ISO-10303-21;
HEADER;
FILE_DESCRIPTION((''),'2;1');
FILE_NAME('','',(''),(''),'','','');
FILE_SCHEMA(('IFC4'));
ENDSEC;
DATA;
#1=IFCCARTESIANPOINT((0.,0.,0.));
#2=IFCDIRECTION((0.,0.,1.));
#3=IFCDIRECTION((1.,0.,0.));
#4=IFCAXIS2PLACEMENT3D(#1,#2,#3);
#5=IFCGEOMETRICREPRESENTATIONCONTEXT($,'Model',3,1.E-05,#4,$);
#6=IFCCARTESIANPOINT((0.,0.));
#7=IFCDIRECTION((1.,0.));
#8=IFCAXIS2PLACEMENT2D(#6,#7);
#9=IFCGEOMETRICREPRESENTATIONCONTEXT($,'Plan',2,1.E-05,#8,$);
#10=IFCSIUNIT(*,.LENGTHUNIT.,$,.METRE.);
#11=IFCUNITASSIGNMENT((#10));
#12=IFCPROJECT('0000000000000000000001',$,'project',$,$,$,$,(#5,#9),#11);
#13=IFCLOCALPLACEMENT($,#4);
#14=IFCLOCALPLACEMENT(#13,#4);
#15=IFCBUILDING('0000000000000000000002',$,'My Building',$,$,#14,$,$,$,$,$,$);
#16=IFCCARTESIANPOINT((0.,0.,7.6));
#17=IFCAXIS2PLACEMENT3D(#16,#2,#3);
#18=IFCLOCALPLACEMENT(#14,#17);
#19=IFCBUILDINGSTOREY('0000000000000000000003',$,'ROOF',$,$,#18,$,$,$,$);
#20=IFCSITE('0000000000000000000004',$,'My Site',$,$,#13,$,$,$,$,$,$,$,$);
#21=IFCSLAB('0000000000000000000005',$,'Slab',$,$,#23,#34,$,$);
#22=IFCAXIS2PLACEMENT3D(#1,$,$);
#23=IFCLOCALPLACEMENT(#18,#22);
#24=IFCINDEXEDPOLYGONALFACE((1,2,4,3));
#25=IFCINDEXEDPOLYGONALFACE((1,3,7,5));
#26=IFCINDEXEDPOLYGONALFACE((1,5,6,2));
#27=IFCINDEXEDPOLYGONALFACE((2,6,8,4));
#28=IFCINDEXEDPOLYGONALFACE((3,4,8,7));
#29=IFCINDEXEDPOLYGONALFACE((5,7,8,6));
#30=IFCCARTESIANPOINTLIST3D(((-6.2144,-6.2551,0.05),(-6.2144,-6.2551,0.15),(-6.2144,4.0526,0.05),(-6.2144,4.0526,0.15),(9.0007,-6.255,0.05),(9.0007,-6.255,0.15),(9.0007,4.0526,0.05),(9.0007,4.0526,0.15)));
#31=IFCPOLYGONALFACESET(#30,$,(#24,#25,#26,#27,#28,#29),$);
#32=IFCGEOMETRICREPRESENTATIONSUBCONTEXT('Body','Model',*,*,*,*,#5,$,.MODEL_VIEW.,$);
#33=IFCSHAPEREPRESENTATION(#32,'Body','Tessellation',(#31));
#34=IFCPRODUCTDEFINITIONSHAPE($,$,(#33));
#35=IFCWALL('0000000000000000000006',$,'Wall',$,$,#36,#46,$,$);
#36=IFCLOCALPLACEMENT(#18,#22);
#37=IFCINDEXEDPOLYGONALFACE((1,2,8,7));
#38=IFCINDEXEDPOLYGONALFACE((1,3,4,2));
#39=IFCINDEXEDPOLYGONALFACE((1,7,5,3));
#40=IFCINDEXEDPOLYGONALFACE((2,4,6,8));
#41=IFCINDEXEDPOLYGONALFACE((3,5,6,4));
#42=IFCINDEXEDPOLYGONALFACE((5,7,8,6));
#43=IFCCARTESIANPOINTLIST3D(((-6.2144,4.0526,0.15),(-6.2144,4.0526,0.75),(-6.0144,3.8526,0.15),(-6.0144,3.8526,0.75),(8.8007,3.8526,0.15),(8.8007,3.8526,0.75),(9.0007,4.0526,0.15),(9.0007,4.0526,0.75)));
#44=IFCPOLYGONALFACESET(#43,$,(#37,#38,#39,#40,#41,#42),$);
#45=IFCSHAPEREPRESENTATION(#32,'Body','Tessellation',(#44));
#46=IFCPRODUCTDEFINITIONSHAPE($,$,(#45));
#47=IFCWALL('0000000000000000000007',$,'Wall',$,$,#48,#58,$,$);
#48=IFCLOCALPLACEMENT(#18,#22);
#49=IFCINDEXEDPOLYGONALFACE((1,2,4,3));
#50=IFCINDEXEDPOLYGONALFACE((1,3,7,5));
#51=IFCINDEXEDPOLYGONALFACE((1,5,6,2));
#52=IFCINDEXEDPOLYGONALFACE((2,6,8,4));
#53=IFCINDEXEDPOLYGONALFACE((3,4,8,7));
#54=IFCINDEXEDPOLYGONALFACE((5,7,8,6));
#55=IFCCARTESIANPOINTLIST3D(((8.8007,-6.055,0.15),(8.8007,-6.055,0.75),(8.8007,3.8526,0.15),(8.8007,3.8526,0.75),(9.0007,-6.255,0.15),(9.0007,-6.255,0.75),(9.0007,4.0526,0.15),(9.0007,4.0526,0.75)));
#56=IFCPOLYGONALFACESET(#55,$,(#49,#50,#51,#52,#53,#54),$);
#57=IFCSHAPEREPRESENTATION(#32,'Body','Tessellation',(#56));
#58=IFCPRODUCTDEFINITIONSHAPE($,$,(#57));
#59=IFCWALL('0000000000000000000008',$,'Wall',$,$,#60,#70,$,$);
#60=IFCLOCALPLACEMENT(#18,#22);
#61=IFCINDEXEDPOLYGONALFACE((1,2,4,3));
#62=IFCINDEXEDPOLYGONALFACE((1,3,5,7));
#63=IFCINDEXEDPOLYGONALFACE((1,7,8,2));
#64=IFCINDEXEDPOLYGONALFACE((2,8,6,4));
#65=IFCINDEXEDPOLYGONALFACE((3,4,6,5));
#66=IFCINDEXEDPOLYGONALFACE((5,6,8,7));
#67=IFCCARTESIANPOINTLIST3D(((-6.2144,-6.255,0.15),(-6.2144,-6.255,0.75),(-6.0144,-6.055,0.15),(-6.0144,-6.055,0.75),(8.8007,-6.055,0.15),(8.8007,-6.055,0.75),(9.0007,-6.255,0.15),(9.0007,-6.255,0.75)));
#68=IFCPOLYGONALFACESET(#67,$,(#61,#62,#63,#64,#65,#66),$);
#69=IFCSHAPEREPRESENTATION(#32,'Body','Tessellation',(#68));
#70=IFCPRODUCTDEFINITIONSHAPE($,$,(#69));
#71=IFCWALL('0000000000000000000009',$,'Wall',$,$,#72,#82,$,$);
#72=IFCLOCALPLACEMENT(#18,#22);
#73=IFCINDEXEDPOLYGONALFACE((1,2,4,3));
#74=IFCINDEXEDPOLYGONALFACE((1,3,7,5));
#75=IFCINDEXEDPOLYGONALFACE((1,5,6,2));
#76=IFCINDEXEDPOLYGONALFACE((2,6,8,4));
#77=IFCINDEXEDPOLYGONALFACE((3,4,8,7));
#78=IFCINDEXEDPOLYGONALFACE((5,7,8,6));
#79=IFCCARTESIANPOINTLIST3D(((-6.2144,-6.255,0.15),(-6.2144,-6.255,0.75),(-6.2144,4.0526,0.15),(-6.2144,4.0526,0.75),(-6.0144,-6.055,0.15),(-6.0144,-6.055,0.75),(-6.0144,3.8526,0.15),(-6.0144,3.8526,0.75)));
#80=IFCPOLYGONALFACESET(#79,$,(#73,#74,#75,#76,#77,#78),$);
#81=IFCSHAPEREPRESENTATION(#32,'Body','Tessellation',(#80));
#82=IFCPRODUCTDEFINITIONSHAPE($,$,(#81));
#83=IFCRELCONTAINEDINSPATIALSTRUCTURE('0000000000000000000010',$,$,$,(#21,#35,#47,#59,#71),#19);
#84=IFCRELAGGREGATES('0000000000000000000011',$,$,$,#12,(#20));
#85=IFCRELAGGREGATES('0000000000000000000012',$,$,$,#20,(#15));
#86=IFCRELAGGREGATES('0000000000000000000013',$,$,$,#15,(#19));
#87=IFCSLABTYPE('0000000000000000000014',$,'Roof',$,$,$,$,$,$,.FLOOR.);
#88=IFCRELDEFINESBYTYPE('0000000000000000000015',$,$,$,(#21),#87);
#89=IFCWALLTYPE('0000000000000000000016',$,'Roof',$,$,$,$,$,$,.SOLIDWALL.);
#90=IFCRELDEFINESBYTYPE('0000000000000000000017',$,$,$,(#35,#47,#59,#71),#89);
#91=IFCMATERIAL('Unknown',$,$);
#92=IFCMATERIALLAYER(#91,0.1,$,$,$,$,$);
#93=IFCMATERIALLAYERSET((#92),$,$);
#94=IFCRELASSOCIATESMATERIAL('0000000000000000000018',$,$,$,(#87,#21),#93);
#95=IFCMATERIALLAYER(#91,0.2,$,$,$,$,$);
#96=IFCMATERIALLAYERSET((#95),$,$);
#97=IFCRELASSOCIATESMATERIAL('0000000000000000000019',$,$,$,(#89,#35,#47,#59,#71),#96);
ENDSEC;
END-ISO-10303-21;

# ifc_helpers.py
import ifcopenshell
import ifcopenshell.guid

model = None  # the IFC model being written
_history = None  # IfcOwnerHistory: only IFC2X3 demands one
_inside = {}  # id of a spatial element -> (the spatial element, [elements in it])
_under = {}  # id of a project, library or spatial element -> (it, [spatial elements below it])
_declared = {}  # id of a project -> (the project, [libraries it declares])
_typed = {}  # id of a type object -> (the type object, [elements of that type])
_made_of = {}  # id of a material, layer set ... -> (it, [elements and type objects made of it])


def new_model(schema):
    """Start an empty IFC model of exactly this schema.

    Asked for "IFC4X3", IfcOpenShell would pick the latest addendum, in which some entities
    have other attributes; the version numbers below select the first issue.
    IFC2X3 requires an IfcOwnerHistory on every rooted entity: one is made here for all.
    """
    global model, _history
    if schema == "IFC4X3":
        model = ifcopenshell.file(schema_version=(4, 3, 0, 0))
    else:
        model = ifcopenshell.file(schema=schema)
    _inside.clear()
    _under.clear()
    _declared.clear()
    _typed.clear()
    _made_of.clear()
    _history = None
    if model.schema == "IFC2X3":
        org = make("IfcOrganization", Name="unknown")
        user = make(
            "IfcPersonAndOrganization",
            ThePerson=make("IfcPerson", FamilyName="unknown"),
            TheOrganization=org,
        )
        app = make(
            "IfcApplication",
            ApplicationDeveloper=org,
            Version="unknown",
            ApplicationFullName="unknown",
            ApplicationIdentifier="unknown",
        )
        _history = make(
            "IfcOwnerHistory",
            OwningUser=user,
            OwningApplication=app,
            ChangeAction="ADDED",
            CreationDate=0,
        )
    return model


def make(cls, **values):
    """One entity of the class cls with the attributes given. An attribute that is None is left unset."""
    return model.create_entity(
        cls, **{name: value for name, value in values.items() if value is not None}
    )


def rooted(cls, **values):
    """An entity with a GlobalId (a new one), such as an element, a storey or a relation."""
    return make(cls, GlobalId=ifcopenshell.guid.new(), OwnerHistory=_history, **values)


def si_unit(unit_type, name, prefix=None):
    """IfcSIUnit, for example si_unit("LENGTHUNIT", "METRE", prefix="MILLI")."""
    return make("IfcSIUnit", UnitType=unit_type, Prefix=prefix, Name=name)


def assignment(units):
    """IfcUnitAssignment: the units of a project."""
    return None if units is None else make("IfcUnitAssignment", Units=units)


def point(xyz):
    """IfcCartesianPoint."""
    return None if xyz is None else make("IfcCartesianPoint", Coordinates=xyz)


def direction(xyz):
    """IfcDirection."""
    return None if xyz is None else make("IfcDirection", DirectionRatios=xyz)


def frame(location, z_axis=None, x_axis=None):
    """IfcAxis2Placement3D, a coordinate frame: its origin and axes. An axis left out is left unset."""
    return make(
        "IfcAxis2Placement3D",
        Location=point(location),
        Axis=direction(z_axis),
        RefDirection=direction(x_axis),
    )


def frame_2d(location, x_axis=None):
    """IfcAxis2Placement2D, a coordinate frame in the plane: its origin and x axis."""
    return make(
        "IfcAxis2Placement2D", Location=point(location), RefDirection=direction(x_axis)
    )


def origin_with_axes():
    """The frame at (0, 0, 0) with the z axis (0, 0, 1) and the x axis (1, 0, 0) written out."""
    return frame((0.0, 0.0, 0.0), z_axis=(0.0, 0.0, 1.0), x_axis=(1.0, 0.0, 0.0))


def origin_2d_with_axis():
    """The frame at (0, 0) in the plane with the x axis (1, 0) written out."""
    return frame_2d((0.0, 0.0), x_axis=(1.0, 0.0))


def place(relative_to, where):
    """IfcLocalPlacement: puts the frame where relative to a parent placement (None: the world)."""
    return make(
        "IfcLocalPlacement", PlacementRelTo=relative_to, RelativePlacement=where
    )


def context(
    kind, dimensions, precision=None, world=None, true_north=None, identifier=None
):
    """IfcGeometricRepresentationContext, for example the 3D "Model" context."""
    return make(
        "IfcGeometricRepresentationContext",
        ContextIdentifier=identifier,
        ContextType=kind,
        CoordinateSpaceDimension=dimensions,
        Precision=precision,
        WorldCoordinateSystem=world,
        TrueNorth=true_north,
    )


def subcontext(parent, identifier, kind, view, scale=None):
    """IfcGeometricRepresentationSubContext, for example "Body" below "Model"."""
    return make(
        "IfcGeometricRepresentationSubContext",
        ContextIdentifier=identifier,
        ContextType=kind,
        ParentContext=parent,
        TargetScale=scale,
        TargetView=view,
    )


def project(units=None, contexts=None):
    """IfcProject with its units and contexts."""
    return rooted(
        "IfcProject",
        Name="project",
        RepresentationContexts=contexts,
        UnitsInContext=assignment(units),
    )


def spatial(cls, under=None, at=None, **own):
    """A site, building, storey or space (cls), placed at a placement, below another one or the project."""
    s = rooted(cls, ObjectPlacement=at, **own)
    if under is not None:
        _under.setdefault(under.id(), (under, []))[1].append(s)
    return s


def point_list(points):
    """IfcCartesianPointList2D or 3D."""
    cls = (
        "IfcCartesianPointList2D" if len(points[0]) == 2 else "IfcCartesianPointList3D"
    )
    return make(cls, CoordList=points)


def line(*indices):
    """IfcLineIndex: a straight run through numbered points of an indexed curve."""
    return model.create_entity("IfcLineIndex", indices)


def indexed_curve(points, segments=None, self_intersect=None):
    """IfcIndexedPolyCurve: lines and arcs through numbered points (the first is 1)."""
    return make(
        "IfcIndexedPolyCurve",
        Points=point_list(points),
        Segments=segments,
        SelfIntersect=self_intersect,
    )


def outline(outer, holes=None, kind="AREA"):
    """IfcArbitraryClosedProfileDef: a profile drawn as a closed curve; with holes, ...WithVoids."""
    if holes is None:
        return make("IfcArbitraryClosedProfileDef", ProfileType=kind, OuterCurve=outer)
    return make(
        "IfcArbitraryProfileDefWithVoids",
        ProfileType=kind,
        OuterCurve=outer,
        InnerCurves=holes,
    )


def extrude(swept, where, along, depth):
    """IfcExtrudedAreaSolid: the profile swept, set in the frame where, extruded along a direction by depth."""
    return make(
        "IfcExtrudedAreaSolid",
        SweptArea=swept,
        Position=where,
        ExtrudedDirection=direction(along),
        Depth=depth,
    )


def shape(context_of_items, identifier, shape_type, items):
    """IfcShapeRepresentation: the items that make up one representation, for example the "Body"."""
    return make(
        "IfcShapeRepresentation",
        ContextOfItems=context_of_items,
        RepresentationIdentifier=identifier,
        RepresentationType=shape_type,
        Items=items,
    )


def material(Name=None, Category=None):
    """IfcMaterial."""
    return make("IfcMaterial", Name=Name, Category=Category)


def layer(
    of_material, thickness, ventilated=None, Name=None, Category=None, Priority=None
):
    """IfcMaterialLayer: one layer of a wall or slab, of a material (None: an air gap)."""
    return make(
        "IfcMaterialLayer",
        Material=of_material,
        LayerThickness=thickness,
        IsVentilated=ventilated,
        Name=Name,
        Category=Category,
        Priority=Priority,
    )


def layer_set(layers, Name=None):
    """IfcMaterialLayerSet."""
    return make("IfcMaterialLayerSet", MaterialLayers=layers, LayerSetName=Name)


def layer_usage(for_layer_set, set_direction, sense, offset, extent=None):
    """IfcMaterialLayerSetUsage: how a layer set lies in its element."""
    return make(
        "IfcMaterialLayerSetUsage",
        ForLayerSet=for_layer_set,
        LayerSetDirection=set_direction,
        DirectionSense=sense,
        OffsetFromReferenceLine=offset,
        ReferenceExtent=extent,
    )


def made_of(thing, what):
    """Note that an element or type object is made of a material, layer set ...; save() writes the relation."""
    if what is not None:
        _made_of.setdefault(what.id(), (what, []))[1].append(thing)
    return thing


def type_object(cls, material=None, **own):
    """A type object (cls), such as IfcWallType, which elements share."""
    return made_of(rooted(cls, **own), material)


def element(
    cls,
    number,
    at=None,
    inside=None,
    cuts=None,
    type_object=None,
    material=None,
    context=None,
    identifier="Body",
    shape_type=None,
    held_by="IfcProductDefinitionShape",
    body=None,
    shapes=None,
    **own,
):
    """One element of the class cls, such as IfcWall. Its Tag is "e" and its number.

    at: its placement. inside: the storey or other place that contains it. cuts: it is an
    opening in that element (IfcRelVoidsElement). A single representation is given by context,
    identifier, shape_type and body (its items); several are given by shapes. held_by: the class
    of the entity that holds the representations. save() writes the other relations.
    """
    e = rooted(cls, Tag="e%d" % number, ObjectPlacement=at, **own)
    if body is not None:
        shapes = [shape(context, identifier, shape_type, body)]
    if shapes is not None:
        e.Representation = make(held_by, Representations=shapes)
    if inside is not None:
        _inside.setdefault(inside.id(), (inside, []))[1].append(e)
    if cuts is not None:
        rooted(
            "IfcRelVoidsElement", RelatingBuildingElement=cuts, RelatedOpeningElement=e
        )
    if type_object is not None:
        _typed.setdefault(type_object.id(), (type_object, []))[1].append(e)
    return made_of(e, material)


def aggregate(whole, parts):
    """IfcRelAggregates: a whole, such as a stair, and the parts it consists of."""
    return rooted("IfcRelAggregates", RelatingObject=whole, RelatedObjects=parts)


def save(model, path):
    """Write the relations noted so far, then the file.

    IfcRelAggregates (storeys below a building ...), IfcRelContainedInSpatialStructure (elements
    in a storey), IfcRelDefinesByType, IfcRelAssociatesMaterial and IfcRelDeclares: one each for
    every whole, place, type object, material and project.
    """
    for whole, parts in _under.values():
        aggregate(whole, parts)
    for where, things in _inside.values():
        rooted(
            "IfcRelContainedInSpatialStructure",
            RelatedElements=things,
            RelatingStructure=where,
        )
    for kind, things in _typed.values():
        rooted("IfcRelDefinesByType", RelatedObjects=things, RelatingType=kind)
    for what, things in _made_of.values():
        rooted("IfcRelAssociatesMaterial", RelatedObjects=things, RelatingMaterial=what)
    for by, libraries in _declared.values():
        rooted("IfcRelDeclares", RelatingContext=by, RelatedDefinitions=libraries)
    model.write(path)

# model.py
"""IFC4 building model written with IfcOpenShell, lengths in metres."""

from ifc_helpers import new_model, si_unit, frame, origin_with_axes, origin_2d_with_axis, place, context, subcontext, project, spatial, line, indexed_curve, outline, extrude, material, layer, layer_set, layer_usage, type_object, element, save


model = new_model("IFC4")

# Units and contexts
model_context = context("Model", 3, precision=1e-05, world=origin_with_axes())
plan_context = context("Plan", 2, precision=1e-05, world=origin_2d_with_axis())
body_context = subcontext(model_context, "Body", "Model", "MODEL_VIEW")
ifc_project = project(units=[si_unit("LENGTHUNIT", "METRE")], contexts=[model_context, plan_context])

# Site, building, storey
site_placement = place(None, origin_with_axes())
site = spatial("IfcSite", under=ifc_project, at=site_placement, Name="My Site")
building_placement = place(site_placement, origin_with_axes())
building = spatial("IfcBuilding", under=site, at=building_placement, Name="My Building")
storey_placement = place(building_placement, frame((0.0, 0.0, 7.6), z_axis=(0.0, 0.0, 1.0), x_axis=(1.0, 0.0, 0.0)))
storey = spatial("IfcBuildingStorey", under=building, at=storey_placement, Name="ROOF")

# Slab
ifc_material = material(Name="Unknown")
ifc_layer_1 = layer(ifc_material, 0.1)
ifc_layer_set_1 = layer_set([ifc_layer_1])
ifc_layer_usage_1 = layer_usage(ifc_layer_set_1, "AXIS3", "POSITIVE", -0.1)
slab_type = type_object("IfcSlabType", Name="Roof", PredefinedType="FLOOR", material=ifc_layer_set_1)
slab_placement = place(storey_placement, frame((9.0007, -6.255, 0.15), z_axis=(0.0, 0.0, 1.0), x_axis=(1.0, 0.0, 0.0)))
element("IfcSlab", 1, at=slab_placement, inside=storey, type_object=slab_type, material=ifc_layer_usage_1, Name="Slab", context=body_context, shape_type="SweptSolid", body=[
    extrude(outline(indexed_curve([(0.0, 0.0), (0.0, 10.3076), (-15.2151, 10.3076), (-15.2151, 0.0), (0.0, 0.0)])), frame((0.0, 0.0, -0.1), z_axis=(0.0, 0.0, 1.0), x_axis=(1.0, 0.0, 0.0)), (0.0, 0.0, 1.0), 0.1),
])

# Walls
ifc_layer_2 = layer(ifc_material, 0.2)
ifc_layer_set_2 = layer_set([ifc_layer_2])
ifc_layer_usage_2 = layer_usage(ifc_layer_set_2, "AXIS2", "POSITIVE", 0.0)
wall_type = type_object("IfcWallType", Name="Roof", PredefinedType="SOLIDWALL", material=ifc_layer_set_2)
wall_1_placement = place(storey_placement, frame((-6.0144, 3.8526, 0.15), z_axis=(0.0, 0.0, 1.0), x_axis=(1.0, 0.0, 0.0)))
element("IfcWall", 2, at=wall_1_placement, inside=storey, type_object=wall_type, material=ifc_layer_usage_2, Name="Wall", context=body_context, shape_type="SweptSolid", body=[
    extrude(outline(indexed_curve([(0.0, 0.0), (-0.2, 0.2), (15.0151, 0.2), (14.8151, 0.0)], segments=[line(1, 2, 3, 4, 1)])), origin_with_axes(), (0.0, 0.0, 1.0), 0.6),
])
ifc_layer_usage_3 = layer_usage(ifc_layer_set_2, "AXIS2", "POSITIVE", 0.0)
wall_2_placement = place(storey_placement, frame((8.8007, 3.8526, 0.15), z_axis=(0.0, 0.0, 1.0), x_axis=(0.0, -1.0, 0.0)))
element("IfcWall", 3, at=wall_2_placement, inside=storey, type_object=wall_type, material=ifc_layer_usage_3, Name="Wall", context=body_context, shape_type="SweptSolid", body=[
    extrude(outline(indexed_curve([(0.0, 0.0), (-0.2, 0.2), (10.1076, 0.2), (9.9076, 0.0)], segments=[line(1, 2, 3, 4, 1)])), origin_with_axes(), (0.0, 0.0, 1.0), 0.6),
])
ifc_layer_usage_4 = layer_usage(ifc_layer_set_2, "AXIS2", "POSITIVE", 0.0)
wall_3_placement = place(storey_placement, frame((8.8007, -6.055, 0.15), z_axis=(0.0, 0.0, 1.0), x_axis=(-1.0, 0.0, 0.0)))
element("IfcWall", 4, at=wall_3_placement, inside=storey, type_object=wall_type, material=ifc_layer_usage_4, Name="Wall", context=body_context, shape_type="SweptSolid", body=[
    extrude(outline(indexed_curve([(0.0, 0.0), (-0.2, 0.2), (15.0151, 0.2), (14.8151, 0.0)], segments=[line(1, 2, 3, 4, 1)])), origin_with_axes(), (0.0, 0.0, 1.0), 0.6),
])
ifc_layer_usage_5 = layer_usage(ifc_layer_set_2, "AXIS2", "POSITIVE", 0.0)
wall_4_placement = place(storey_placement, frame((-6.0144, -6.055, 0.15), z_axis=(0.0, 0.0, 1.0), x_axis=(0.0, 1.0, 0.0)))
element("IfcWall", 5, at=wall_4_placement, inside=storey, type_object=wall_type, material=ifc_layer_usage_5, Name="Wall", context=body_context, shape_type="SweptSolid", body=[
    extrude(outline(indexed_curve([(0.0, 0.0), (-0.2, 0.2), (10.1076, 0.2), (9.9076, 0.0)], segments=[line(1, 2, 3, 4, 1)])), origin_with_axes(), (0.0, 0.0, 1.0), 0.6),
])

save(model, "model.ifc")
